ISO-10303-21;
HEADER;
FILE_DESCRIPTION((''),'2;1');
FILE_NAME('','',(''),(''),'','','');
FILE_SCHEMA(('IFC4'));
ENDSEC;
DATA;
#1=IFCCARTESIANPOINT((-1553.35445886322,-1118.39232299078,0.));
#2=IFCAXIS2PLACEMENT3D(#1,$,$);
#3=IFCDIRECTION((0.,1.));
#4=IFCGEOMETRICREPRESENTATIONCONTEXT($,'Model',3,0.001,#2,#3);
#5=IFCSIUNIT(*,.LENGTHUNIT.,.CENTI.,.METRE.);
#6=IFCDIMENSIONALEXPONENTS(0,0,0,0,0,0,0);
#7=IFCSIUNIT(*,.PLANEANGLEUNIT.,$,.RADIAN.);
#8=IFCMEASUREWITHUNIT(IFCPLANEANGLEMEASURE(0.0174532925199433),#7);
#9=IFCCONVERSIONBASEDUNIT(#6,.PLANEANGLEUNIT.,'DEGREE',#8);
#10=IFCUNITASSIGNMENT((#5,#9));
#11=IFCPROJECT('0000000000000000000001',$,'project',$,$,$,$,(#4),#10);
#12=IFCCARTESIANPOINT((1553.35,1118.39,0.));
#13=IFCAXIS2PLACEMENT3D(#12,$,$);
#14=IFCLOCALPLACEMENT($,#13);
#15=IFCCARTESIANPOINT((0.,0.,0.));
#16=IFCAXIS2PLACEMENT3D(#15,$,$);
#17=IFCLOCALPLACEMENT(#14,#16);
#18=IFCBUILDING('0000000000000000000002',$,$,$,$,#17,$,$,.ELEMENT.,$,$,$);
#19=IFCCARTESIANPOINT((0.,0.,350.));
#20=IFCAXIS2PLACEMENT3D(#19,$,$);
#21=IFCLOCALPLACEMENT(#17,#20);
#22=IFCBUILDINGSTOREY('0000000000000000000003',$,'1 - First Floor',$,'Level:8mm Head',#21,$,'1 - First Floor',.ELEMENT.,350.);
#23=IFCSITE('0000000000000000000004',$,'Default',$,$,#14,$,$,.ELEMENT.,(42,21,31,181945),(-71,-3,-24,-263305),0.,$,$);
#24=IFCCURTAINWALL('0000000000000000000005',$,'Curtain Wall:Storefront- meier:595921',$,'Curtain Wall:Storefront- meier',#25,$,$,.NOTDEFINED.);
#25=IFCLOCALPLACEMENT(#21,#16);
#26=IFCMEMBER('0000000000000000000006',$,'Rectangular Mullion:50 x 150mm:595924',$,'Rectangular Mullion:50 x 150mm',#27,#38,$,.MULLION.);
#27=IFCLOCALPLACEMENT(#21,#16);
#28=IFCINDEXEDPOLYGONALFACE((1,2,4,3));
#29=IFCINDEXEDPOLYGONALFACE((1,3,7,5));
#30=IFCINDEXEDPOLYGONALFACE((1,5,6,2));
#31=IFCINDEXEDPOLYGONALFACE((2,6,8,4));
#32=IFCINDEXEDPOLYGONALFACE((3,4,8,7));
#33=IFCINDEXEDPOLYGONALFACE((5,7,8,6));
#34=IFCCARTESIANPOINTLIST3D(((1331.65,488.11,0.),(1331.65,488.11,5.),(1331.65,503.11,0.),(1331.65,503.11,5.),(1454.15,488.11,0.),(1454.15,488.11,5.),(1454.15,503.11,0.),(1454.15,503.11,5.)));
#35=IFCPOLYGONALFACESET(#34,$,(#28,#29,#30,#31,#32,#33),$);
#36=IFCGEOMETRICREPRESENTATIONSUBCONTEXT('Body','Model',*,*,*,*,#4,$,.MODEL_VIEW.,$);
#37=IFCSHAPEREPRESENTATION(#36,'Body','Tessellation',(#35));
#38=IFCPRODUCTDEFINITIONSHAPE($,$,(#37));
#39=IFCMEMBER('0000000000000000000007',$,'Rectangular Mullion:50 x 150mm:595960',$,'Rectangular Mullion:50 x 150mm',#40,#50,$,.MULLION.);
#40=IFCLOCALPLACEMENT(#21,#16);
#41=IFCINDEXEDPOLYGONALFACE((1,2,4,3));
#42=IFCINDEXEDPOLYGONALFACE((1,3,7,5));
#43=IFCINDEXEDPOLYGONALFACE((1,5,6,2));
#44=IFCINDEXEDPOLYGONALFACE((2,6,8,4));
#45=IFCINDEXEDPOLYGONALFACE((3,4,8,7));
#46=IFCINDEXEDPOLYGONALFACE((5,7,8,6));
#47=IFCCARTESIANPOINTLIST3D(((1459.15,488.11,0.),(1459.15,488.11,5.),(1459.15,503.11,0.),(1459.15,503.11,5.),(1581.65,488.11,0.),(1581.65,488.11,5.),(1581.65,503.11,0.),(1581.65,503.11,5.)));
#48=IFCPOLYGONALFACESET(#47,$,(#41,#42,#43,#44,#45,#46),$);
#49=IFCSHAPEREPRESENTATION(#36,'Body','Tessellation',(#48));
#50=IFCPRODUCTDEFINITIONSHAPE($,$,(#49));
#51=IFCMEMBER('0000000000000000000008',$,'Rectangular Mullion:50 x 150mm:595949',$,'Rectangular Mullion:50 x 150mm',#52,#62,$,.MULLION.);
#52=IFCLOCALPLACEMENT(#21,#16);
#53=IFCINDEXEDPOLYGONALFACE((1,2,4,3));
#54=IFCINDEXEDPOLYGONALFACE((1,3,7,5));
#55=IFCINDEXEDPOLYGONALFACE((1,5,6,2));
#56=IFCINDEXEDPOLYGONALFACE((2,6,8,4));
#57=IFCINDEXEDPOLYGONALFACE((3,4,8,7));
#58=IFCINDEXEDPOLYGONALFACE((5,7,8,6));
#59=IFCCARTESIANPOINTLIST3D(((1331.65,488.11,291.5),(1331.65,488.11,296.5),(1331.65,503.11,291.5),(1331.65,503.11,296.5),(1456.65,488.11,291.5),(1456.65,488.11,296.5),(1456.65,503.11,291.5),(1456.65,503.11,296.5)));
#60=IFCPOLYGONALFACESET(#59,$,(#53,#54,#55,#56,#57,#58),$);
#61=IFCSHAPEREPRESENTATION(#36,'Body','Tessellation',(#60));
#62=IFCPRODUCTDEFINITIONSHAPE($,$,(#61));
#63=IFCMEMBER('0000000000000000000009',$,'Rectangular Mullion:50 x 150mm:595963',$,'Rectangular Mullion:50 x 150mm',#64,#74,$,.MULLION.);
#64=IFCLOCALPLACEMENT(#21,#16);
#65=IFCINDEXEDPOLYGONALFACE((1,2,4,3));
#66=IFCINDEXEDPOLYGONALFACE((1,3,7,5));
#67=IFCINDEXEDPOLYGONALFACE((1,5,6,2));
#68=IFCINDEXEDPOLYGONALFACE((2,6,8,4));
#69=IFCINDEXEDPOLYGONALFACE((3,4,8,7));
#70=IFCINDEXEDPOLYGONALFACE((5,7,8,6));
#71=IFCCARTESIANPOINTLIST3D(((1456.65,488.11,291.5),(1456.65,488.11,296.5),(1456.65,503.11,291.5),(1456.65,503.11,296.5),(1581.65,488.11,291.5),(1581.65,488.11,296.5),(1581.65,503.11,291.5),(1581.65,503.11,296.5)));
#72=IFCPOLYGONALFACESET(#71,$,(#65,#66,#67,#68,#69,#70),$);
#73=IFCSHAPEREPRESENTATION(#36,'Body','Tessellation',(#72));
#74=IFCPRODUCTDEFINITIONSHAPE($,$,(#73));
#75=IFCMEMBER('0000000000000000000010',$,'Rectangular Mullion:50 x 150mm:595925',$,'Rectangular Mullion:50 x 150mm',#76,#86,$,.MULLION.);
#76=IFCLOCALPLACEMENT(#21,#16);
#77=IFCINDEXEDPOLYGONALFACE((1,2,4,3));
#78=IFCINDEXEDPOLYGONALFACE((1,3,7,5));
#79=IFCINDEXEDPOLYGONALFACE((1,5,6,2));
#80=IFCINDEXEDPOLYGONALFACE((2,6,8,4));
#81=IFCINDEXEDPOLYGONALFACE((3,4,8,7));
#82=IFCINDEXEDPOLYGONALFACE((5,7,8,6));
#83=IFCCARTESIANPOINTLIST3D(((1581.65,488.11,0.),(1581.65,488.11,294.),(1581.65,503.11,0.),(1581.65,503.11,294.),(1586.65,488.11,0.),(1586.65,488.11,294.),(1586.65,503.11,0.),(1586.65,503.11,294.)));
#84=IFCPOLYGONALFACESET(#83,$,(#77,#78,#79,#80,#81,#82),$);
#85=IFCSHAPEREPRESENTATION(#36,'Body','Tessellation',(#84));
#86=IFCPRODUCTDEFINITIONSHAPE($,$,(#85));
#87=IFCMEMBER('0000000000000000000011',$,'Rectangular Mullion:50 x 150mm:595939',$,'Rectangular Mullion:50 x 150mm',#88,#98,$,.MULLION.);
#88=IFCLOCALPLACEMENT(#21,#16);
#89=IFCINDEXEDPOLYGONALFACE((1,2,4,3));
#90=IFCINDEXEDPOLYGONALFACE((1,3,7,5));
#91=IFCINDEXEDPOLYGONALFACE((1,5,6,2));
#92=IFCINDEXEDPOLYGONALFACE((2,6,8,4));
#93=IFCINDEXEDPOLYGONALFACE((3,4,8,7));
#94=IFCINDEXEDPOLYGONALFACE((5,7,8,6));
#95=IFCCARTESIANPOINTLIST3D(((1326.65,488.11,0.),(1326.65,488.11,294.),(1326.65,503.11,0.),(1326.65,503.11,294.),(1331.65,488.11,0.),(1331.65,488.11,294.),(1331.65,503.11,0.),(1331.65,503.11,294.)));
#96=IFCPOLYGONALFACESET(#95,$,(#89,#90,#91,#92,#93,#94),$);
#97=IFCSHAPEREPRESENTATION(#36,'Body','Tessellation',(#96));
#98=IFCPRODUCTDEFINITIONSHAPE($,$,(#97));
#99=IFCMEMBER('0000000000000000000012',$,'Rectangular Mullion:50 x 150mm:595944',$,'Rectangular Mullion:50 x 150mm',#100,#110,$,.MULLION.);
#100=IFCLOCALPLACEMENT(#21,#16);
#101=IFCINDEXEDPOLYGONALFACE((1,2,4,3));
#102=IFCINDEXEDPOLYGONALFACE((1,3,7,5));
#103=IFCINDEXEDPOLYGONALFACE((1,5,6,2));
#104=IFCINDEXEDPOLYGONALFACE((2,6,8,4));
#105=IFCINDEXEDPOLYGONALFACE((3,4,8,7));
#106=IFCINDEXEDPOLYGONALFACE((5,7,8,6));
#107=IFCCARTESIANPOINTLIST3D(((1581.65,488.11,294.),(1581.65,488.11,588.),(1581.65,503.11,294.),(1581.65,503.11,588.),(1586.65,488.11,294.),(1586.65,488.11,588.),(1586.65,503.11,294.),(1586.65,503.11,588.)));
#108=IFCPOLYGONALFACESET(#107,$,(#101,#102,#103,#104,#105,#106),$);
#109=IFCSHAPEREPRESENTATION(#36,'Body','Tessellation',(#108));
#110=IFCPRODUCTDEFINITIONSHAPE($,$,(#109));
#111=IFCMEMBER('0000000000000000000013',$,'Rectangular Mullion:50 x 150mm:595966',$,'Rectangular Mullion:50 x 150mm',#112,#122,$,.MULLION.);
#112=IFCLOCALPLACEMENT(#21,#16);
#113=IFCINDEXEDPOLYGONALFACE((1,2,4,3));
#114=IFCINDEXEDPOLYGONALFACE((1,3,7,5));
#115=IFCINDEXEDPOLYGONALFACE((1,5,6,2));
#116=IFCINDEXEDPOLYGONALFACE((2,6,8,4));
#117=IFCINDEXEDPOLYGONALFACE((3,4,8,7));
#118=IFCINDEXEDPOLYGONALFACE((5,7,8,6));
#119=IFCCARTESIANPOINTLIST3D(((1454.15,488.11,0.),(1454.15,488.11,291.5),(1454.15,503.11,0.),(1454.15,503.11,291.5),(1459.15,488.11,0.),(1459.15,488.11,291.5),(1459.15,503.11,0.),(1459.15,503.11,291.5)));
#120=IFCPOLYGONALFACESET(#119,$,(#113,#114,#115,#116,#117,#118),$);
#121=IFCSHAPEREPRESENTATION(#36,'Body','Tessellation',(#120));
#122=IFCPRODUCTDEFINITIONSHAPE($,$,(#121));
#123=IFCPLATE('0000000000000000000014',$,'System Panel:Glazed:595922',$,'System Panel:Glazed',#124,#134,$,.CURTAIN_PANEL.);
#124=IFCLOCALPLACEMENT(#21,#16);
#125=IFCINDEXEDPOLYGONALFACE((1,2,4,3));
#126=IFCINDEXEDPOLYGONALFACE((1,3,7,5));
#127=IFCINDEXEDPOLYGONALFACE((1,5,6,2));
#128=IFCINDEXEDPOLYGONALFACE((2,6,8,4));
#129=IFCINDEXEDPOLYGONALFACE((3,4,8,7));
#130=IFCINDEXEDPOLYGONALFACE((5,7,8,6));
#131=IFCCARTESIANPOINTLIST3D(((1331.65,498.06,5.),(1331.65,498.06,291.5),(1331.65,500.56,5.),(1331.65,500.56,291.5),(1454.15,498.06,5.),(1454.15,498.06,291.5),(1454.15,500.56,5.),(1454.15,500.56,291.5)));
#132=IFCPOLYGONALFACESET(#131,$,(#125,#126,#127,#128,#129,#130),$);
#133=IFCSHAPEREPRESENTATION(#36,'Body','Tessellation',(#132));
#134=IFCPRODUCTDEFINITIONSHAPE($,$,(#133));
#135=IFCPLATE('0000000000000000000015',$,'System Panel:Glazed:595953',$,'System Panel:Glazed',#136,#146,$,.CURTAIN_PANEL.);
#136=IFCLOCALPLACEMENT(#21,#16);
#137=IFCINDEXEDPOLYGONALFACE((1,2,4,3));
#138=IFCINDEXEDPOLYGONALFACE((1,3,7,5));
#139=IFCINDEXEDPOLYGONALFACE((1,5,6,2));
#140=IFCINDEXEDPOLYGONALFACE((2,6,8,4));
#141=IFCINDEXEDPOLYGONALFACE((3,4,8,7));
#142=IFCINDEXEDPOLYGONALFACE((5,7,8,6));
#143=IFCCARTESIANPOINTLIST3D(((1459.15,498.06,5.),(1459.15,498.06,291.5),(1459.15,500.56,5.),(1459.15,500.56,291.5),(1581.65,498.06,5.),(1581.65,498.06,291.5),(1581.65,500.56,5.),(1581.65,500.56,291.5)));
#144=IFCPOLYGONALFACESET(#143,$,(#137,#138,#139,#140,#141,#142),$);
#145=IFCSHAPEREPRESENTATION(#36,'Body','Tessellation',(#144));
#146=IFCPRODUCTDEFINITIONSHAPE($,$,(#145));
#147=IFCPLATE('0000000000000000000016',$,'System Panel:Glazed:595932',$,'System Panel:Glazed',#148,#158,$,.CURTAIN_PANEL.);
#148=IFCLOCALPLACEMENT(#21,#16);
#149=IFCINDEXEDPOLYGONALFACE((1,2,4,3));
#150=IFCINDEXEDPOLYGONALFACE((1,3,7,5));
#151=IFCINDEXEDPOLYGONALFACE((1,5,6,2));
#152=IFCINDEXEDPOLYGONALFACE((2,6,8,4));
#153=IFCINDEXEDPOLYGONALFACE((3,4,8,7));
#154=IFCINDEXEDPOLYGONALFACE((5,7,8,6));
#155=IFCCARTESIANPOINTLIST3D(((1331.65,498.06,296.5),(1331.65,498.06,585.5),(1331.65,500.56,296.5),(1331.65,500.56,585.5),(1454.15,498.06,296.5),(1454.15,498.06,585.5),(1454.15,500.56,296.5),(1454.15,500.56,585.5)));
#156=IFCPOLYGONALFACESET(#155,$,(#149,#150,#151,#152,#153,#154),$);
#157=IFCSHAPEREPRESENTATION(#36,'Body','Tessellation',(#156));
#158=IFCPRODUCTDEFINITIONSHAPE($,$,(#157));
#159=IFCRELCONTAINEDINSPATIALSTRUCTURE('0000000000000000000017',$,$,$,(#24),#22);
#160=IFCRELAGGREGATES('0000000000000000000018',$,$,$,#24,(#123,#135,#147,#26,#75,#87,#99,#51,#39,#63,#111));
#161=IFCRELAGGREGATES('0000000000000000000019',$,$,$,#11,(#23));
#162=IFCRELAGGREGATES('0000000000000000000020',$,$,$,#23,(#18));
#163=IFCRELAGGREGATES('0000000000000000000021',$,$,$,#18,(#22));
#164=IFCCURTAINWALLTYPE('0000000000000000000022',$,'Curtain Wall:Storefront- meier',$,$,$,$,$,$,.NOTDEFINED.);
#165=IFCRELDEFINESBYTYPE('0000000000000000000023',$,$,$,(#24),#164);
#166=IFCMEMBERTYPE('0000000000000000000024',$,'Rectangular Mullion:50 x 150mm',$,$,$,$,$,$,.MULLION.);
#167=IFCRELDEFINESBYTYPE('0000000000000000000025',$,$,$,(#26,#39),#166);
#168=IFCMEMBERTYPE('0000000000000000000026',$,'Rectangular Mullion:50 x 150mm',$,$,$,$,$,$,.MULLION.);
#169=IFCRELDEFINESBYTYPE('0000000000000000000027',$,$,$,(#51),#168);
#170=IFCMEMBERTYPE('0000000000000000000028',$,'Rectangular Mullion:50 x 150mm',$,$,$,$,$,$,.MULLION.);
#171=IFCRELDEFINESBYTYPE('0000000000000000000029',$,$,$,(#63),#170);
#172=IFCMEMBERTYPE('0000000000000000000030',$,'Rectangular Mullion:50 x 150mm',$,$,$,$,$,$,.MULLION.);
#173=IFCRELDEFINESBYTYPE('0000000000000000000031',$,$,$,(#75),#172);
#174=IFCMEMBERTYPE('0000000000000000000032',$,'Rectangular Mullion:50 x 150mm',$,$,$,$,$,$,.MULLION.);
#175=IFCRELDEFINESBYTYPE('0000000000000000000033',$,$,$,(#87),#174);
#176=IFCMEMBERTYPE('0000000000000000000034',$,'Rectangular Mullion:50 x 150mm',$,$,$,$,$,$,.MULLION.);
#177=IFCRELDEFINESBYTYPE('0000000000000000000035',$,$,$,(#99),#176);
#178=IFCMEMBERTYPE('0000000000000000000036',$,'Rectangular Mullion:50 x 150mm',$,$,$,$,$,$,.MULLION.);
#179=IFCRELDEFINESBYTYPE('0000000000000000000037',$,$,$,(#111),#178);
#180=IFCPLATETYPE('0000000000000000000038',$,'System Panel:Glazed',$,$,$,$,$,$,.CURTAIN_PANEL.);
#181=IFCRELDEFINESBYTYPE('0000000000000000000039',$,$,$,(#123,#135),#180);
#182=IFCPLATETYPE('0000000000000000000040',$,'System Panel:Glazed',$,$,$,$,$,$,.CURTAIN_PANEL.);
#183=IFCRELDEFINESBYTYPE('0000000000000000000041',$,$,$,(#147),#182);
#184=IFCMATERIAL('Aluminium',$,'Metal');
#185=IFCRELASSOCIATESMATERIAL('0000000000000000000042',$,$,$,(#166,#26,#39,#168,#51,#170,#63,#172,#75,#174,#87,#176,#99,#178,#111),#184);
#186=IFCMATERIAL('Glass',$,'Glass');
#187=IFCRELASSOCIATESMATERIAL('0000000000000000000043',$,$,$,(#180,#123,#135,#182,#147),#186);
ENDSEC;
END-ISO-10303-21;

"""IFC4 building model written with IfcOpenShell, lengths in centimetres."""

from ifc_helpers import new_model, entity, si_unit, converted_unit, direction, frame, origin, place, context, subcontext, project, spatial, indexed_curve, outline, extrude, source, transform, mapped, material, type_object, type_shapes, element, aggregate, save


model = new_model("IFC4")

# Units and contexts
model_context = context("Model", 3, precision=0.001, world=frame((-1553.35445886322, -1118.39232299078, 0.0)), true_north=direction((0.0, 1.0)))
body_context = subcontext(model_context, "Body", "Model", "MODEL_VIEW")
ifc_project = project(units=[si_unit("LENGTHUNIT", "METRE", prefix="CENTI"), converted_unit("PLANEANGLEUNIT", "DEGREE", entity("IfcPlaneAngleMeasure", 0.0174532925199433), si_unit("PLANEANGLEUNIT", "RADIAN"), dimensions=[0, 0, 0, 0, 0, 0, 0])], contexts=[model_context])

# Site, building, storey
site_placement = place(None, frame((1553.35, 1118.39, 0.0)))
site = spatial("IfcSite", under=ifc_project, at=site_placement, Name="Default", CompositionType="ELEMENT", RefLatitude=(42, 21, 31, 181945), RefLongitude=(-71, -3, -24, -263305), RefElevation=0.0)
building_placement = place(site_placement, origin())
building = spatial("IfcBuilding", under=site, at=building_placement, CompositionType="ELEMENT")
storey_placement = place(building_placement, frame((0.0, 0.0, 350.0)))
storey = spatial("IfcBuildingStorey", under=building, at=storey_placement, Name="1 - First Floor", ObjectType="Level:8mm Head", LongName="1 - First Floor", CompositionType="ELEMENT", Elevation=350.0)

# Curtain wall, members, plates
curtain_wall_type = type_object("IfcCurtainWallType", Name="Curtain Wall:Storefront- meier", PredefinedType="NOTDEFINED")
curtain_wall_placement = place(storey_placement, frame((0.0, 0.0, -350.0)))
curtain_wall = element("IfcCurtainWall", 1, at=curtain_wall_placement, inside=storey, type_object=curtain_wall_type, Name="Curtain Wall:Storefront- meier:595921", ObjectType="Curtain Wall:Storefront- meier", PredefinedType="NOTDEFINED")
ifc_material_1 = material(Name="Aluminium", Category="Metal")
member_type_1 = type_object("IfcMemberType", Name="Rectangular Mullion:50 x 150mm", PredefinedType="MULLION", material=ifc_material_1)
shared_shape_1 = source(origin(), body_context, "Body", "SweptSolid", [
    extrude(outline(indexed_curve([(-2.5, -7.5), (2.5, -7.5), (2.5, 7.5), (-2.5, 7.5), (-2.5, -7.5)], self_intersect=False)), frame((-2.5, 0.0, -122.5), z_axis=(0.0, 0.0, 1.0), x_axis=(-1.0, 0.0, 0.0)), (0.0, 0.0, 1.0), 122.5),
])
type_shapes(member_type_1, [shared_shape_1])
member_1_placement = place(curtain_wall_placement, frame((1331.65, 495.61, 350.0), z_axis=(-1.0, 0.0, 0.0), x_axis=(0.0, 0.0, -1.0)))
member_1 = element("IfcMember", 2, at=member_1_placement, type_object=member_type_1, material=ifc_material_1, Name="Rectangular Mullion:50 x 150mm:595924", ObjectType="Rectangular Mullion:50 x 150mm", PredefinedType="MULLION", context=body_context, shape_type="MappedRepresentation", body=[
    mapped(shared_shape_1, transform((0.0, 0.0, 0.0), scale=1.0)),
])
member_2_placement = place(curtain_wall_placement, frame((1459.15, 495.61, 350.0), z_axis=(-1.0, 0.0, 0.0), x_axis=(0.0, 0.0, -1.0)))
member_2 = element("IfcMember", 3, at=member_2_placement, type_object=member_type_1, material=ifc_material_1, Name="Rectangular Mullion:50 x 150mm:595960", ObjectType="Rectangular Mullion:50 x 150mm", PredefinedType="MULLION", context=body_context, shape_type="MappedRepresentation", body=[
    mapped(shared_shape_1, transform((0.0, 0.0, 0.0), scale=1.0)),
])
member_type_2 = type_object("IfcMemberType", Name="Rectangular Mullion:50 x 150mm", PredefinedType="MULLION", material=ifc_material_1)
shared_shape_2 = source(origin(), body_context, "Body", "SweptSolid", [
    extrude(outline(indexed_curve([(-2.5, -7.5), (2.5, -7.5), (2.5, 7.5), (-2.5, 7.5), (-2.5, -7.5)], self_intersect=False)), frame((0.0, 0.0, -125.0), z_axis=(0.0, 0.0, 1.0), x_axis=(-1.0, 0.0, 0.0)), (0.0, 0.0, 1.0), 125.0),
])
type_shapes(member_type_2, [shared_shape_2])
member_3_placement = place(curtain_wall_placement, frame((1456.65, 495.61, 644.0), z_axis=(1.0, 0.0, 0.0), x_axis=(0.0, 0.0, 1.0)))
member_3 = element("IfcMember", 4, at=member_3_placement, type_object=member_type_2, material=ifc_material_1, Name="Rectangular Mullion:50 x 150mm:595949", ObjectType="Rectangular Mullion:50 x 150mm", PredefinedType="MULLION", context=body_context, shape_type="MappedRepresentation", body=[
    mapped(shared_shape_2, transform((0.0, 0.0, 0.0), scale=1.0)),
])
member_type_3 = type_object("IfcMemberType", Name="Rectangular Mullion:50 x 150mm", PredefinedType="MULLION", material=ifc_material_1)
shared_shape_3 = source(origin(), body_context, "Body", "SweptSolid", [
    extrude(outline(indexed_curve([(-2.5, -7.5), (2.5, -7.5), (2.5, 7.5), (-2.5, 7.5), (-2.5, -7.5)], self_intersect=False)), frame((0.0, 0.0, -125.0), z_axis=(0.0, 0.0, 1.0), x_axis=(-1.0, 0.0, 0.0)), (0.0, 0.0, 1.0), 125.0),
])
type_shapes(member_type_3, [shared_shape_3])
member_4_placement = place(curtain_wall_placement, frame((1581.65, 495.61, 644.0), z_axis=(1.0, 0.0, 0.0), x_axis=(0.0, 0.0, 1.0)))
member_4 = element("IfcMember", 5, at=member_4_placement, type_object=member_type_3, material=ifc_material_1, Name="Rectangular Mullion:50 x 150mm:595963", ObjectType="Rectangular Mullion:50 x 150mm", PredefinedType="MULLION", context=body_context, shape_type="MappedRepresentation", body=[
    mapped(shared_shape_3, transform((0.0, 0.0, 0.0), scale=1.0)),
])
member_type_4 = type_object("IfcMemberType", Name="Rectangular Mullion:50 x 150mm", PredefinedType="MULLION", material=ifc_material_1)
shared_shape_4 = source(origin(), body_context, "Body", "SweptSolid", [
    extrude(outline(indexed_curve([(-2.5, -7.5), (2.5, -7.5), (2.5, 7.5), (-2.5, 7.5), (-2.5, -7.5)], self_intersect=False)), frame((-2.5, 0.0, -294.0), z_axis=(0.0, 0.0, 1.0), x_axis=(-1.0, 0.0, 0.0)), (0.0, 0.0, 1.0), 294.0),
])
type_shapes(member_type_4, [shared_shape_4])
member_5_placement = place(curtain_wall_placement, frame((1586.65, 495.61, 350.0), z_axis=(0.0, 0.0, -1.0), x_axis=(1.0, 0.0, 0.0)))
member_5 = element("IfcMember", 6, at=member_5_placement, type_object=member_type_4, material=ifc_material_1, Name="Rectangular Mullion:50 x 150mm:595925", ObjectType="Rectangular Mullion:50 x 150mm", PredefinedType="MULLION", context=body_context, shape_type="MappedRepresentation", body=[
    mapped(shared_shape_4, transform((0.0, 0.0, 0.0), scale=1.0)),
])
member_type_5 = type_object("IfcMemberType", Name="Rectangular Mullion:50 x 150mm", PredefinedType="MULLION", material=ifc_material_1)
shared_shape_5 = source(origin(), body_context, "Body", "SweptSolid", [
    extrude(outline(indexed_curve([(-2.5, -7.5), (2.5, -7.5), (2.5, 7.5), (-2.5, 7.5), (-2.5, -7.5)], self_intersect=False)), frame((-2.5, 0.0, -294.0), z_axis=(0.0, 0.0, 1.0), x_axis=(-1.0, 0.0, 0.0)), (0.0, 0.0, 1.0), 294.0),
])
type_shapes(member_type_5, [shared_shape_5])
member_6_placement = place(curtain_wall_placement, frame((1326.65, 495.61, 644.0), z_axis=(0.0, 0.0, 1.0), x_axis=(-1.0, 0.0, 0.0)))
member_6 = element("IfcMember", 7, at=member_6_placement, type_object=member_type_5, material=ifc_material_1, Name="Rectangular Mullion:50 x 150mm:595939", ObjectType="Rectangular Mullion:50 x 150mm", PredefinedType="MULLION", context=body_context, shape_type="MappedRepresentation", body=[
    mapped(shared_shape_5, transform((0.0, 0.0, 0.0), scale=1.0)),
])
member_type_6 = type_object("IfcMemberType", Name="Rectangular Mullion:50 x 150mm", PredefinedType="MULLION", material=ifc_material_1)
shared_shape_6 = source(origin(), body_context, "Body", "SweptSolid", [
    extrude(outline(indexed_curve([(-2.5, -7.5), (2.5, -7.5), (2.5, 7.5), (-2.5, 7.5), (-2.5, -7.5)], self_intersect=False)), frame((-2.5, 0.0, -294.0), z_axis=(0.0, 0.0, 1.0), x_axis=(-1.0, 0.0, 0.0)), (0.0, 0.0, 1.0), 294.0),
])
type_shapes(member_type_6, [shared_shape_6])
member_7_placement = place(curtain_wall_placement, frame((1586.65, 495.61, 644.0), z_axis=(0.0, 0.0, -1.0), x_axis=(1.0, 0.0, 0.0)))
member_7 = element("IfcMember", 8, at=member_7_placement, type_object=member_type_6, material=ifc_material_1, Name="Rectangular Mullion:50 x 150mm:595944", ObjectType="Rectangular Mullion:50 x 150mm", PredefinedType="MULLION", context=body_context, shape_type="MappedRepresentation", body=[
    mapped(shared_shape_6, transform((0.0, 0.0, 0.0), scale=1.0)),
])
member_type_7 = type_object("IfcMemberType", Name="Rectangular Mullion:50 x 150mm", PredefinedType="MULLION", material=ifc_material_1)
shared_shape_7 = source(origin(), body_context, "Body", "SweptSolid", [
    extrude(outline(indexed_curve([(-2.5, -7.5), (2.5, -7.5), (2.5, 7.5), (-2.5, 7.5), (-2.5, -7.5)], self_intersect=False)), frame((0.0, 0.0, -291.5), z_axis=(0.0, 0.0, 1.0), x_axis=(-1.0, 0.0, 0.0)), (0.0, 0.0, 1.0), 291.5),
])
type_shapes(member_type_7, [shared_shape_7])
member_8_placement = place(curtain_wall_placement, frame((1456.65, 495.61, 350.0), z_axis=(0.0, 0.0, -1.0), x_axis=(1.0, 0.0, 0.0)))
member_8 = element("IfcMember", 9, at=member_8_placement, type_object=member_type_7, material=ifc_material_1, Name="Rectangular Mullion:50 x 150mm:595966", ObjectType="Rectangular Mullion:50 x 150mm", PredefinedType="MULLION", context=body_context, shape_type="MappedRepresentation", body=[
    mapped(shared_shape_7, transform((0.0, 0.0, 0.0), scale=1.0)),
])
ifc_material_2 = material(Name="Glass", Category="Glass")
plate_type_1 = type_object("IfcPlateType", Name="System Panel:Glazed", PredefinedType="CURTAIN_PANEL", material=ifc_material_2)
shared_shape_8 = source(origin(), body_context, "Body", "SweptSolid", [
    extrude(outline(indexed_curve([(-1.25, -61.25), (1.25, -61.25), (1.25, 61.25), (-1.25, 61.25), (-1.25, -61.25)], self_intersect=False)), frame((0.0, 3.7, 0.0), z_axis=(0.0, 0.0, 1.0), x_axis=(0.0, 1.0, 0.0)), (0.0, 0.0, 1.0), 286.5),
])
type_shapes(plate_type_1, [shared_shape_8])
plate_1_placement = place(curtain_wall_placement, frame((1392.9, 495.61, 355.0)))
plate_1 = element("IfcPlate", 10, at=plate_1_placement, type_object=plate_type_1, material=ifc_material_2, Name="System Panel:Glazed:595922", ObjectType="System Panel:Glazed", PredefinedType="CURTAIN_PANEL", context=body_context, shape_type="MappedRepresentation", body=[
    mapped(shared_shape_8, transform((0.0, 0.0, 0.0), scale=1.0)),
])
plate_2_placement = place(curtain_wall_placement, frame((1520.4, 495.61, 355.0)))
plate_2 = element("IfcPlate", 11, at=plate_2_placement, type_object=plate_type_1, material=ifc_material_2, Name="System Panel:Glazed:595953", ObjectType="System Panel:Glazed", PredefinedType="CURTAIN_PANEL", context=body_context, shape_type="MappedRepresentation", body=[
    mapped(shared_shape_8, transform((0.0, 0.0, 0.0), scale=1.0)),
])
plate_type_2 = type_object("IfcPlateType", Name="System Panel:Glazed", PredefinedType="CURTAIN_PANEL", material=ifc_material_2)
shared_shape_9 = source(origin(), body_context, "Body", "SweptSolid", [
    extrude(outline(indexed_curve([(-1.25, -61.25), (1.25, -61.25), (1.25, 61.25), (-1.25, 61.25), (-1.25, -61.25)], self_intersect=False)), frame((0.0, 3.7, 0.0), z_axis=(0.0, 0.0, 1.0), x_axis=(0.0, 1.0, 0.0)), (0.0, 0.0, 1.0), 289.0),
])
type_shapes(plate_type_2, [shared_shape_9])
plate_3_placement = place(curtain_wall_placement, frame((1392.9, 495.61, 646.5)))
plate_3 = element("IfcPlate", 12, at=plate_3_placement, type_object=plate_type_2, material=ifc_material_2, Name="System Panel:Glazed:595932", ObjectType="System Panel:Glazed", PredefinedType="CURTAIN_PANEL", context=body_context, shape_type="MappedRepresentation", body=[
    mapped(shared_shape_9, transform((0.0, 0.0, 0.0), scale=1.0)),
])
aggregate(curtain_wall, [plate_1, plate_2, plate_3, member_1, member_5, member_6, member_7, member_3, member_2, member_4, member_8])

save(model, "model.ifc")
